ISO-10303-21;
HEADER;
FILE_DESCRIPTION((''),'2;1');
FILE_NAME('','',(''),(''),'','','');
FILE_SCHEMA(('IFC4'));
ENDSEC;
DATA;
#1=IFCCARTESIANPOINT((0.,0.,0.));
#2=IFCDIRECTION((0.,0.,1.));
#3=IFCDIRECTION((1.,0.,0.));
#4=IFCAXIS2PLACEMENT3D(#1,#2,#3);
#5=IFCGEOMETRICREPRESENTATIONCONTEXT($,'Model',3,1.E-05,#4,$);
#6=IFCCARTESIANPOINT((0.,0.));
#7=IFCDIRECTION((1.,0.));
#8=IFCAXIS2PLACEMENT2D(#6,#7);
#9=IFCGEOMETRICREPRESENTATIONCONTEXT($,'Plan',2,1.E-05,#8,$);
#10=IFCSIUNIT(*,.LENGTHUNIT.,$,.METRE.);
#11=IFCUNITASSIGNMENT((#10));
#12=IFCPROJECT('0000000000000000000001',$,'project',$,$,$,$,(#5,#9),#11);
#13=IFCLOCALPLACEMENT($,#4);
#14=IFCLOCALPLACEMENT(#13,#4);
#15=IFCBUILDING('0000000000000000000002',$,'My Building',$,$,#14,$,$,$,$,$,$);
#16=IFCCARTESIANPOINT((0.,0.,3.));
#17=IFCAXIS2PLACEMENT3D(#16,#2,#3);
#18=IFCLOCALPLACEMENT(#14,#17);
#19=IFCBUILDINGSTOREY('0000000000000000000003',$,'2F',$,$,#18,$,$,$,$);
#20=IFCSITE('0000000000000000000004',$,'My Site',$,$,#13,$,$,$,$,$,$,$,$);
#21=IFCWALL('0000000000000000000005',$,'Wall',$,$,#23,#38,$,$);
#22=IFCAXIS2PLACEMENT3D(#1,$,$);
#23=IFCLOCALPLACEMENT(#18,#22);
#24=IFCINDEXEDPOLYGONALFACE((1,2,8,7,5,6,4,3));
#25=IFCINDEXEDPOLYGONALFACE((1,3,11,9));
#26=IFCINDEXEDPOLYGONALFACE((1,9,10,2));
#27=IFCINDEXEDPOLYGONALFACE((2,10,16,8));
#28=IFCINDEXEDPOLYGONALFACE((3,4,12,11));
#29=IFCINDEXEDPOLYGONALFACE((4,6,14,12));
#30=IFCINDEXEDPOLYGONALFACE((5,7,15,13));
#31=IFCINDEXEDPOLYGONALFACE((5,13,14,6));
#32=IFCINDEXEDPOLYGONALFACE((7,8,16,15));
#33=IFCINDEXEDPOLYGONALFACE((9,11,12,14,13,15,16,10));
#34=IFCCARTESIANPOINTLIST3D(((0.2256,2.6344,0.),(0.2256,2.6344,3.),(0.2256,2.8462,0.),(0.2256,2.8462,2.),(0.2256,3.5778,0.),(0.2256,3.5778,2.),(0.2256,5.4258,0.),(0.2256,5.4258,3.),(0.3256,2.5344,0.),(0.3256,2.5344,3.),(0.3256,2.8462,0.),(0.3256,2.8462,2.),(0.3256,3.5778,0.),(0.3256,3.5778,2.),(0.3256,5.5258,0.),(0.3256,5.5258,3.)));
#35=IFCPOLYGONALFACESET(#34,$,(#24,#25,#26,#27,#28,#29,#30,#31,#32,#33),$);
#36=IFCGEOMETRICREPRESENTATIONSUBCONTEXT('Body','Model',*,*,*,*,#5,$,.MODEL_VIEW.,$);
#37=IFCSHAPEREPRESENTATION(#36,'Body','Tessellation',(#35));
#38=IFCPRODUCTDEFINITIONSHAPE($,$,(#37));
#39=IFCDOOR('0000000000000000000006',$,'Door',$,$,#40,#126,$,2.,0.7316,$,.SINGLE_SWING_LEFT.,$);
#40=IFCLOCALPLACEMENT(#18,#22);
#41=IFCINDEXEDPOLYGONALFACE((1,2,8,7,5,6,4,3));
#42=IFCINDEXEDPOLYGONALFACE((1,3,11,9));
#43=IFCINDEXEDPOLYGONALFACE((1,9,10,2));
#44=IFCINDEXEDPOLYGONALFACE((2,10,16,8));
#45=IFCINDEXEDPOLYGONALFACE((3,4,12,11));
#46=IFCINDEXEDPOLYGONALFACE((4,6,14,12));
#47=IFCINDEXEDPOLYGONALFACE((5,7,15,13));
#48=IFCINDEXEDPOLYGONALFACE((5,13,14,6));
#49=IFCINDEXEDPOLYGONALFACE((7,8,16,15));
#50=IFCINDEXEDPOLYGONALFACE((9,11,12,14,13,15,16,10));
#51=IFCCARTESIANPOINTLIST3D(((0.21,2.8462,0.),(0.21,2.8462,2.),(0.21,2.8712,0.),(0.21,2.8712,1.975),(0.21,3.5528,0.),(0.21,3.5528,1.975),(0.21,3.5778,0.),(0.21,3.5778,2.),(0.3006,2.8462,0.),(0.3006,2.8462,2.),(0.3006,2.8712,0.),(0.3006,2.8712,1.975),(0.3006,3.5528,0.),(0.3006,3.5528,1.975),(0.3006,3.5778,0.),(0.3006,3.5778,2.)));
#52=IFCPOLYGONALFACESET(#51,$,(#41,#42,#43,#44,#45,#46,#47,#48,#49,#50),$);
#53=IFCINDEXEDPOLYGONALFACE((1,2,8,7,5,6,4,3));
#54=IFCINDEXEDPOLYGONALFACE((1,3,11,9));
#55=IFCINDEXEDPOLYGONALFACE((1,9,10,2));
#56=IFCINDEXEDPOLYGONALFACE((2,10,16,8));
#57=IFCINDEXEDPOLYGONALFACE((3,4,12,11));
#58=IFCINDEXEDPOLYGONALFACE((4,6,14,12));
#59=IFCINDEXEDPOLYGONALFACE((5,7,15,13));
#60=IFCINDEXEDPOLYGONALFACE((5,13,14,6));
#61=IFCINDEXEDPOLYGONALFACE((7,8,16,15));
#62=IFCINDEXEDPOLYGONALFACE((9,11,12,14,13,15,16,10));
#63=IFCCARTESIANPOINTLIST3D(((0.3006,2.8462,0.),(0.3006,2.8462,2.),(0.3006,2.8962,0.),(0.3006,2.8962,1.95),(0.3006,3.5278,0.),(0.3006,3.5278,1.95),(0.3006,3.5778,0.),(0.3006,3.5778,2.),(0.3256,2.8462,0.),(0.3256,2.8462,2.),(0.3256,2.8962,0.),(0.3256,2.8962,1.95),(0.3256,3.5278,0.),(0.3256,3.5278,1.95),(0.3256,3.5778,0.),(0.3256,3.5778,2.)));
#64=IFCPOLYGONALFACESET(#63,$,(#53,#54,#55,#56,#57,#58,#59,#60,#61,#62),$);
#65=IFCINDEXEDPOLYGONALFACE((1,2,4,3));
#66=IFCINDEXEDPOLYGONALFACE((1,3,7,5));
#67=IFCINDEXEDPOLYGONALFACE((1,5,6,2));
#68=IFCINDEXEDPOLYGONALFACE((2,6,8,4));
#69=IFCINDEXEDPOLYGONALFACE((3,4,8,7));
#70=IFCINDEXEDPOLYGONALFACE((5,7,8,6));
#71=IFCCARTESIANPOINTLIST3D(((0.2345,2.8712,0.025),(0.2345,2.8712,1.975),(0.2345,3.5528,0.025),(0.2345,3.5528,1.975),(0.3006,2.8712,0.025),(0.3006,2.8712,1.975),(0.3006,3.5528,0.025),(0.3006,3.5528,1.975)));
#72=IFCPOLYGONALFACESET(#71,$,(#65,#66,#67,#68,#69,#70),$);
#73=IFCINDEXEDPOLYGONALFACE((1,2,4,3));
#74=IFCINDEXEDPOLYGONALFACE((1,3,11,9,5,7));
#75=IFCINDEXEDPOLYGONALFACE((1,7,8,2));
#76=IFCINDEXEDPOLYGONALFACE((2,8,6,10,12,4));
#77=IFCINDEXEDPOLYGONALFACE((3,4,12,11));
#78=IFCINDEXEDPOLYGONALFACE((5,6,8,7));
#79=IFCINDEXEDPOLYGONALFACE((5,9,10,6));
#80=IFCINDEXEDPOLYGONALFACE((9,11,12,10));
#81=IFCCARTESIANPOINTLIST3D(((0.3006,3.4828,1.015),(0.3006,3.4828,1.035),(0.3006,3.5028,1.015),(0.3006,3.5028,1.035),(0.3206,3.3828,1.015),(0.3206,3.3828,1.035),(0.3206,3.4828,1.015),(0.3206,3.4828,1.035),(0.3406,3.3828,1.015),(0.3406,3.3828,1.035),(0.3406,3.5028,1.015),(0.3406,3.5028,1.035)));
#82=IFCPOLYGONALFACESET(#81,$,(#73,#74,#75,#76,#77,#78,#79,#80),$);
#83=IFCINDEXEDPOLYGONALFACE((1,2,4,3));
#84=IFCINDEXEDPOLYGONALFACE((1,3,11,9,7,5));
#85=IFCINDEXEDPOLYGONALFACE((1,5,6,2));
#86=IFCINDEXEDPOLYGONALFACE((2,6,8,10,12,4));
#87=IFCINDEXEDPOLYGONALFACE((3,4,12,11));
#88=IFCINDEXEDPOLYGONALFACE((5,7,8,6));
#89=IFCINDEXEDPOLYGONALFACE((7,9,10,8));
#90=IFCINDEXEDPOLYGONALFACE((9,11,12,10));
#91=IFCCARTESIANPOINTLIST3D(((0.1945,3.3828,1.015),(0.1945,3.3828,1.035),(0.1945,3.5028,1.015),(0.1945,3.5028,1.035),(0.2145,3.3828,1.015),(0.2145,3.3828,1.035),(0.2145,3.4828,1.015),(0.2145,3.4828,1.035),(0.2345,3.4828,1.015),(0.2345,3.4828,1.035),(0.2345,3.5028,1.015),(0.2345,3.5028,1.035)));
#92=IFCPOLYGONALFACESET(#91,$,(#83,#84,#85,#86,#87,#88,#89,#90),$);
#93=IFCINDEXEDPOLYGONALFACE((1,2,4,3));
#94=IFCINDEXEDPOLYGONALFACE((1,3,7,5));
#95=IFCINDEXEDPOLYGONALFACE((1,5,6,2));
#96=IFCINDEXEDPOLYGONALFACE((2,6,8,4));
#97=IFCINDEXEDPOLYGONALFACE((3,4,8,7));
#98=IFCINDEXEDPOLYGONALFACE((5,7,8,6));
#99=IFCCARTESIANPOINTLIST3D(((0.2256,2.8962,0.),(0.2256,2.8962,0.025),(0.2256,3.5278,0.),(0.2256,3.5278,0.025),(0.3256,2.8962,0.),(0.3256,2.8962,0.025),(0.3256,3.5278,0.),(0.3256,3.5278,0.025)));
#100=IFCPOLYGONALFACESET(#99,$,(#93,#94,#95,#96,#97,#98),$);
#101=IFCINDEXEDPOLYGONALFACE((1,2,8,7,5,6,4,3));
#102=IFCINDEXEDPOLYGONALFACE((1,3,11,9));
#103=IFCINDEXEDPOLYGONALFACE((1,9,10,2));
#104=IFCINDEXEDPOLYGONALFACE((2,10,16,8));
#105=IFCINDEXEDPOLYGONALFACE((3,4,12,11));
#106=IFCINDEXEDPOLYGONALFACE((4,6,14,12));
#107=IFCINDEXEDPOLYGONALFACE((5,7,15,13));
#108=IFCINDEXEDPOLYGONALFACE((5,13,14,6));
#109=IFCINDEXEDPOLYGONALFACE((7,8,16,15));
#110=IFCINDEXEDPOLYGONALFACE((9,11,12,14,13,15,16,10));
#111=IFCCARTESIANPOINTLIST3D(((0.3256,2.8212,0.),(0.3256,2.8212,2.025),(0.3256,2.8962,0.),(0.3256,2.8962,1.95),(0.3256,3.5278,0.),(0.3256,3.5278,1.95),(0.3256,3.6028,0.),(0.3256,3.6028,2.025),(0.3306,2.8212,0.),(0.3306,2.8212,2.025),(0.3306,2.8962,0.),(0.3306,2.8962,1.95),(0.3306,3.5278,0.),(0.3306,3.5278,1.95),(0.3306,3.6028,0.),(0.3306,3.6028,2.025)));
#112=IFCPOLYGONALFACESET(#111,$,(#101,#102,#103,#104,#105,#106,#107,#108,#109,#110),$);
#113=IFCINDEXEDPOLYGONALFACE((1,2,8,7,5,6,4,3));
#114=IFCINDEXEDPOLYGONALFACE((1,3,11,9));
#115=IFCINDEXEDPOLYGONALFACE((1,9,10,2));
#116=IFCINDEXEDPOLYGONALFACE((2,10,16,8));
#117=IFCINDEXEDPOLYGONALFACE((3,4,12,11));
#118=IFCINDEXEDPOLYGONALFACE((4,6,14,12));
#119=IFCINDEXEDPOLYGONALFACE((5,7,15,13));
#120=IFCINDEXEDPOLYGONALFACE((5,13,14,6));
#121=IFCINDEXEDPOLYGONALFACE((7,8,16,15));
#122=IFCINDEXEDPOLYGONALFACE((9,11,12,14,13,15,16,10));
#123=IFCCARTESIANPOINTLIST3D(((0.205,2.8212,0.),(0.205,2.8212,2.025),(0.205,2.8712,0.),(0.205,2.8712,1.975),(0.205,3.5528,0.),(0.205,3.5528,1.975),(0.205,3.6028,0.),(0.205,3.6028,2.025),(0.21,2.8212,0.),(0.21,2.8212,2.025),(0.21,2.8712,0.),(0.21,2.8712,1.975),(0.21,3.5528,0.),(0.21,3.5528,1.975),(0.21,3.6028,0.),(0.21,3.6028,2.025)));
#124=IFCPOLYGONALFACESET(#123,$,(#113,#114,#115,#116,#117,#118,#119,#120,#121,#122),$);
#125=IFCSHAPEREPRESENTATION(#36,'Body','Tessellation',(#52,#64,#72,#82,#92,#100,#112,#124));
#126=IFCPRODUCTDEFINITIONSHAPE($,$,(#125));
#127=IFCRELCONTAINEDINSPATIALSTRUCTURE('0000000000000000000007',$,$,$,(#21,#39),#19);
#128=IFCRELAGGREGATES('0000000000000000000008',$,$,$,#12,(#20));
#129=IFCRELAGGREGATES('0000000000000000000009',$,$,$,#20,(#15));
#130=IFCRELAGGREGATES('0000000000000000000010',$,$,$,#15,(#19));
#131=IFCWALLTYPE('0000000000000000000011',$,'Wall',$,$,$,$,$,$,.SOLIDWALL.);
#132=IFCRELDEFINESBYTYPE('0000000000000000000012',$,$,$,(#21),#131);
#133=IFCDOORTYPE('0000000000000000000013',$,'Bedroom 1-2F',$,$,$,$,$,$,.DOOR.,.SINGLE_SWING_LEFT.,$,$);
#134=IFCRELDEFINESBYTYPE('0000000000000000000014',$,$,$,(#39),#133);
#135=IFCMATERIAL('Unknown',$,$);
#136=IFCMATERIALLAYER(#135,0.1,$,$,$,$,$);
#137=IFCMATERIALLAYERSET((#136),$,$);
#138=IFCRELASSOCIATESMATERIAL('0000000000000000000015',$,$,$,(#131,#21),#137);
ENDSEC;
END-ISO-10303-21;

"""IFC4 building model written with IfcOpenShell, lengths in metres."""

from ifc_helpers import new_model, entity, si_unit, frame, origin_with_axes, origin_2d_with_axis, place, context, subcontext, project, spatial, line, indexed_curve, outline, extrude, shape, source, transform, mapped, material, layer, layer_set, layer_usage, type_object, type_shapes, element, fill, save


model = new_model("IFC4")

# Units and contexts
model_context = context("Model", 3, precision=1e-05, world=origin_with_axes())
plan_context = context("Plan", 2, precision=1e-05, world=origin_2d_with_axis())
body_context_1 = subcontext(model_context, "Body", "Model", "MODEL_VIEW")
body_context_2 = subcontext(plan_context, "Body", "Plan", "PLAN_VIEW")
ifc_project = project(units=[si_unit("LENGTHUNIT", "METRE")], contexts=[model_context, plan_context])

# Site, building, storey
site_placement = place(None, origin_with_axes())
site = spatial("IfcSite", under=ifc_project, at=site_placement, Name="My Site")
building_placement = place(site_placement, origin_with_axes())
building = spatial("IfcBuilding", under=site, at=building_placement, Name="My Building")
storey_placement = place(building_placement, frame((0.0, 0.0, 3.0), z_axis=(0.0, 0.0, 1.0), x_axis=(1.0, 0.0, 0.0)))
storey = spatial("IfcBuildingStorey", under=building, at=storey_placement, Name="2F")

# Shared definitions
ifc_material = material(Name="Unknown")

# Shared definitions
ifc_layer = layer(ifc_material, 0.1)
ifc_layer_set = layer_set([ifc_layer])
wall_type = type_object("IfcWallType", Name="Wall", PredefinedType="SOLIDWALL", material=ifc_layer_set)

# Wall, opening, door
ifc_layer_usage_1 = layer_usage(ifc_layer_set, "AXIS2", "POSITIVE", 0.0)
wall_1_placement = place(storey_placement, frame((0.2256, 5.5258, 0.0), z_axis=(0.0, 0.0, 1.0), x_axis=(0.0, -1.0, 0.0)))
wall_1 = element("IfcWall", 1, at=wall_1_placement, inside=storey, type_object=wall_type, material=ifc_layer_usage_1, Name="Wall", context=body_context_1, shape_type="SweptSolid", body=[
    extrude(outline(indexed_curve([(0.1, 0.0), (0.0, 0.1), (2.9914, 0.1), (2.8914, 0.0)], segments=[line(1, 2, 3, 4, 1)])), origin_with_axes(), (0.0, 0.0, 1.0), 3.0),
])
shared_shape_1 = source(origin_with_axes(), body_context_1, "Body", "SweptSolid", [
    extrude(outline(indexed_curve([(0.0, 0.0), (0.7316, 0.0), (0.7316, 2.0), (0.0, 2.0)], segments=[line(1, 2, 3, 4, 1)])), frame((0.0, -0.6, 0.0), z_axis=(0.0, -1.0, 0.0), x_axis=(1.0, 0.0, 0.0)), (0.0, 0.0, -1.0), 1.2),
])
opening_1_placement = place(wall_1_placement, frame((2.6795, 0.1, 0.0), z_axis=(0.0, 0.0, 1.0), x_axis=(-1.0, 0.0, 0.0)))
opening_1 = element("IfcOpeningElement", 2, at=opening_1_placement, cuts=wall_1, PredefinedType="OPENING", context=body_context_1, shape_type="MappedRepresentation", body=[
    mapped(shared_shape_1, transform((0.0, 0.0, 0.0), x_axis=(1.0, 0.0, 0.0), y_axis=(0.0, 1.0, 0.0), z_axis=(0.0, 0.0, 1.0), scale=1.0)),
])
door_type_1 = type_object("IfcDoorType", Name="Bedroom 1-2F", OperationType="SINGLE_SWING_LEFT", PredefinedType="DOOR")
shared_shape_2 = source(origin_with_axes(), body_context_1, "Body", "SweptSolid", [
    extrude(outline(indexed_curve([(0.0, 0.0), (0.0, 2.0), (0.7316, 2.0), (0.7316, 0.0), (0.7066, 0.0), (0.7066, 1.975), (0.025, 1.975), (0.025, 0.0)], segments=[line(1, 2, 3, 4, 5, 6, 7, 8, 1)])), frame((0.0, 0.025, 0.0), z_axis=(0.0, -1.0, 0.0), x_axis=(1.0, 0.0, 0.0)), (0.0, 0.0, -1.0), 0.0906),
    extrude(outline(indexed_curve([(0.0, 0.0), (0.0, 2.0), (0.7316, 2.0), (0.7316, 0.0), (0.6816, 0.0), (0.6816, 1.95), (0.05, 1.95), (0.05, 0.0)], segments=[line(1, 2, 3, 4, 5, 6, 7, 8, 1)])), frame((0.0, 0.0, 0.0), z_axis=(0.0, -1.0, 0.0), x_axis=(1.0, 0.0, 0.0)), (0.0, 0.0, -1.0), 0.025),
    extrude(outline(indexed_curve([(0.0, 0.0), (0.6816, 0.0), (0.6816, 0.0661), (0.0, 0.0661)], segments=[line(1, 2, 3, 4, 1)])), frame((0.025, 0.025, 0.025), z_axis=(0.0, 0.0, 1.0), x_axis=(1.0, 0.0, 0.0)), (0.0, 0.0, 1.0), 1.95),
    extrude(outline(indexed_curve([(0.0, 0.0), (0.0, -0.04), (-0.12, -0.04), (-0.12, -0.02), (-0.02, -0.02), (-0.02, 0.0)], segments=[line(1, 2, 3, 4, 5, 6, 1)])), frame((0.6566, 0.025, 1.015), z_axis=(0.0, 0.0, 1.0), x_axis=(1.0, 0.0, 0.0)), (0.0, 0.0, 1.0), 0.02),
    extrude(outline(indexed_curve([(0.0, 0.0), (0.0, 0.04), (-0.12, 0.04), (-0.12, 0.02), (-0.02, 0.02), (-0.02, 0.0)], segments=[line(1, 2, 3, 4, 5, 6, 1)])), frame((0.6566, 0.0911, 1.015), z_axis=(0.0, 0.0, 1.0), x_axis=(1.0, 0.0, 0.0)), (0.0, 0.0, 1.0), 0.02),
    extrude(outline(indexed_curve([(0.0, 0.0), (0.6316, 0.0), (0.6316, 0.1), (0.0, 0.1)], segments=[line(1, 2, 3, 4, 1)])), frame((0.05, 0.0, 0.0), z_axis=(0.0, 0.0, 1.0), x_axis=(1.0, 0.0, 0.0)), (0.0, 0.0, 1.0), 0.025),
    extrude(outline(indexed_curve([(0.0, 0.0), (0.0, 2.025), (0.7816, 2.025), (0.7816, 0.0), (0.7066, 0.0), (0.7066, 1.95), (0.075, 1.95), (0.075, 0.0)], segments=[line(1, 2, 3, 4, 5, 6, 7, 8, 1)])), frame((-0.025, -0.005, 0.0), z_axis=(0.0, -1.0, 0.0), x_axis=(1.0, 0.0, 0.0)), (0.0, 0.0, -1.0), 0.005),
    extrude(outline(indexed_curve([(0.0, 0.0), (0.0, 2.025), (0.7816, 2.025), (0.7816, 0.0), (0.7316, 0.0), (0.7316, 1.975), (0.05, 1.975), (0.05, 0.0)], segments=[line(1, 2, 3, 4, 5, 6, 7, 8, 1)])), frame((-0.025, 0.1156, 0.0), z_axis=(0.0, -1.0, 0.0), x_axis=(1.0, 0.0, 0.0)), (0.0, 0.0, -1.0), 0.005),
])
shared_shape_3 = source(origin_with_axes(), body_context_2, "Body", "Curve2D", [
    entity("IfcIndexedPolyCurve", entity("IfcCartesianPointList2D", [[0.0, 0.0], [0.0, 0.1156], [0.025, 0.1156], [0.025, 0.025], [0.05, 0.025], [0.05, 0.0]]), [entity("IfcLineIndex", [1, 2, 3, 4, 5, 6, 1])]),
    entity("IfcIndexedPolyCurve", entity("IfcCartesianPointList2D", [[0.7316, 0.0], [0.7316, 0.1156], [0.7066, 0.1156], [0.7066, 0.025], [0.6816, 0.025], [0.6816, 0.0]]), [entity("IfcLineIndex", [1, 2, 3, 4, 5, 6, 1])]),
    entity("IfcTrimmedCurve", entity("IfcEllipse", entity("IfcAxis2Placement2D", entity("IfcCartesianPoint", [0.0911, 0.1156]), entity("IfcDirection", [1.0, 0.0])), 0.6155, 0.6816), [entity("IfcCartesianPoint", [0.7066, 0.1156])], [entity("IfcCartesianPoint", [0.0911, 0.7972])], True, "CARTESIAN"),
    entity("IfcIndexedPolyCurve", entity("IfcCartesianPointList2D", [[0.025, 0.1156], [0.0911, 0.1156], [0.0911, 0.7972], [0.025, 0.7972]]), [entity("IfcLineIndex", [1, 2, 3, 4, 1])]),
])
type_shapes(door_type_1, [shared_shape_2, shared_shape_3])
door_1_placement = place(opening_1_placement, frame((0.0, 0.0, 0.0), z_axis=(0.0, 0.0, 1.0), x_axis=(1.0, 0.0, 0.0)))
door_1 = element("IfcDoor", 3, at=door_1_placement, inside=storey, type_object=door_type_1, Name="Door", OperationType="SINGLE_SWING_LEFT", OverallHeight=2.0, OverallWidth=0.7316, shapes=[
    shape(body_context_1, "Body", "MappedRepresentation", [mapped(shared_shape_2, transform((0.0, 0.0, 0.0), x_axis=(1.0, 0.0, 0.0), y_axis=(0.0, 1.0, 0.0), z_axis=(0.0, 0.0, 1.0), scale=1.0))]),
    shape(body_context_2, "Body", "MappedRepresentation", [mapped(shared_shape_3, transform((0.0, 0.0, 0.0), x_axis=(1.0, 0.0, 0.0), y_axis=(0.0, 1.0, 0.0), z_axis=(0.0, 0.0, 1.0), scale=1.0))]),
])
fill(opening_1, door_1)

save(model, "model.ifc")
